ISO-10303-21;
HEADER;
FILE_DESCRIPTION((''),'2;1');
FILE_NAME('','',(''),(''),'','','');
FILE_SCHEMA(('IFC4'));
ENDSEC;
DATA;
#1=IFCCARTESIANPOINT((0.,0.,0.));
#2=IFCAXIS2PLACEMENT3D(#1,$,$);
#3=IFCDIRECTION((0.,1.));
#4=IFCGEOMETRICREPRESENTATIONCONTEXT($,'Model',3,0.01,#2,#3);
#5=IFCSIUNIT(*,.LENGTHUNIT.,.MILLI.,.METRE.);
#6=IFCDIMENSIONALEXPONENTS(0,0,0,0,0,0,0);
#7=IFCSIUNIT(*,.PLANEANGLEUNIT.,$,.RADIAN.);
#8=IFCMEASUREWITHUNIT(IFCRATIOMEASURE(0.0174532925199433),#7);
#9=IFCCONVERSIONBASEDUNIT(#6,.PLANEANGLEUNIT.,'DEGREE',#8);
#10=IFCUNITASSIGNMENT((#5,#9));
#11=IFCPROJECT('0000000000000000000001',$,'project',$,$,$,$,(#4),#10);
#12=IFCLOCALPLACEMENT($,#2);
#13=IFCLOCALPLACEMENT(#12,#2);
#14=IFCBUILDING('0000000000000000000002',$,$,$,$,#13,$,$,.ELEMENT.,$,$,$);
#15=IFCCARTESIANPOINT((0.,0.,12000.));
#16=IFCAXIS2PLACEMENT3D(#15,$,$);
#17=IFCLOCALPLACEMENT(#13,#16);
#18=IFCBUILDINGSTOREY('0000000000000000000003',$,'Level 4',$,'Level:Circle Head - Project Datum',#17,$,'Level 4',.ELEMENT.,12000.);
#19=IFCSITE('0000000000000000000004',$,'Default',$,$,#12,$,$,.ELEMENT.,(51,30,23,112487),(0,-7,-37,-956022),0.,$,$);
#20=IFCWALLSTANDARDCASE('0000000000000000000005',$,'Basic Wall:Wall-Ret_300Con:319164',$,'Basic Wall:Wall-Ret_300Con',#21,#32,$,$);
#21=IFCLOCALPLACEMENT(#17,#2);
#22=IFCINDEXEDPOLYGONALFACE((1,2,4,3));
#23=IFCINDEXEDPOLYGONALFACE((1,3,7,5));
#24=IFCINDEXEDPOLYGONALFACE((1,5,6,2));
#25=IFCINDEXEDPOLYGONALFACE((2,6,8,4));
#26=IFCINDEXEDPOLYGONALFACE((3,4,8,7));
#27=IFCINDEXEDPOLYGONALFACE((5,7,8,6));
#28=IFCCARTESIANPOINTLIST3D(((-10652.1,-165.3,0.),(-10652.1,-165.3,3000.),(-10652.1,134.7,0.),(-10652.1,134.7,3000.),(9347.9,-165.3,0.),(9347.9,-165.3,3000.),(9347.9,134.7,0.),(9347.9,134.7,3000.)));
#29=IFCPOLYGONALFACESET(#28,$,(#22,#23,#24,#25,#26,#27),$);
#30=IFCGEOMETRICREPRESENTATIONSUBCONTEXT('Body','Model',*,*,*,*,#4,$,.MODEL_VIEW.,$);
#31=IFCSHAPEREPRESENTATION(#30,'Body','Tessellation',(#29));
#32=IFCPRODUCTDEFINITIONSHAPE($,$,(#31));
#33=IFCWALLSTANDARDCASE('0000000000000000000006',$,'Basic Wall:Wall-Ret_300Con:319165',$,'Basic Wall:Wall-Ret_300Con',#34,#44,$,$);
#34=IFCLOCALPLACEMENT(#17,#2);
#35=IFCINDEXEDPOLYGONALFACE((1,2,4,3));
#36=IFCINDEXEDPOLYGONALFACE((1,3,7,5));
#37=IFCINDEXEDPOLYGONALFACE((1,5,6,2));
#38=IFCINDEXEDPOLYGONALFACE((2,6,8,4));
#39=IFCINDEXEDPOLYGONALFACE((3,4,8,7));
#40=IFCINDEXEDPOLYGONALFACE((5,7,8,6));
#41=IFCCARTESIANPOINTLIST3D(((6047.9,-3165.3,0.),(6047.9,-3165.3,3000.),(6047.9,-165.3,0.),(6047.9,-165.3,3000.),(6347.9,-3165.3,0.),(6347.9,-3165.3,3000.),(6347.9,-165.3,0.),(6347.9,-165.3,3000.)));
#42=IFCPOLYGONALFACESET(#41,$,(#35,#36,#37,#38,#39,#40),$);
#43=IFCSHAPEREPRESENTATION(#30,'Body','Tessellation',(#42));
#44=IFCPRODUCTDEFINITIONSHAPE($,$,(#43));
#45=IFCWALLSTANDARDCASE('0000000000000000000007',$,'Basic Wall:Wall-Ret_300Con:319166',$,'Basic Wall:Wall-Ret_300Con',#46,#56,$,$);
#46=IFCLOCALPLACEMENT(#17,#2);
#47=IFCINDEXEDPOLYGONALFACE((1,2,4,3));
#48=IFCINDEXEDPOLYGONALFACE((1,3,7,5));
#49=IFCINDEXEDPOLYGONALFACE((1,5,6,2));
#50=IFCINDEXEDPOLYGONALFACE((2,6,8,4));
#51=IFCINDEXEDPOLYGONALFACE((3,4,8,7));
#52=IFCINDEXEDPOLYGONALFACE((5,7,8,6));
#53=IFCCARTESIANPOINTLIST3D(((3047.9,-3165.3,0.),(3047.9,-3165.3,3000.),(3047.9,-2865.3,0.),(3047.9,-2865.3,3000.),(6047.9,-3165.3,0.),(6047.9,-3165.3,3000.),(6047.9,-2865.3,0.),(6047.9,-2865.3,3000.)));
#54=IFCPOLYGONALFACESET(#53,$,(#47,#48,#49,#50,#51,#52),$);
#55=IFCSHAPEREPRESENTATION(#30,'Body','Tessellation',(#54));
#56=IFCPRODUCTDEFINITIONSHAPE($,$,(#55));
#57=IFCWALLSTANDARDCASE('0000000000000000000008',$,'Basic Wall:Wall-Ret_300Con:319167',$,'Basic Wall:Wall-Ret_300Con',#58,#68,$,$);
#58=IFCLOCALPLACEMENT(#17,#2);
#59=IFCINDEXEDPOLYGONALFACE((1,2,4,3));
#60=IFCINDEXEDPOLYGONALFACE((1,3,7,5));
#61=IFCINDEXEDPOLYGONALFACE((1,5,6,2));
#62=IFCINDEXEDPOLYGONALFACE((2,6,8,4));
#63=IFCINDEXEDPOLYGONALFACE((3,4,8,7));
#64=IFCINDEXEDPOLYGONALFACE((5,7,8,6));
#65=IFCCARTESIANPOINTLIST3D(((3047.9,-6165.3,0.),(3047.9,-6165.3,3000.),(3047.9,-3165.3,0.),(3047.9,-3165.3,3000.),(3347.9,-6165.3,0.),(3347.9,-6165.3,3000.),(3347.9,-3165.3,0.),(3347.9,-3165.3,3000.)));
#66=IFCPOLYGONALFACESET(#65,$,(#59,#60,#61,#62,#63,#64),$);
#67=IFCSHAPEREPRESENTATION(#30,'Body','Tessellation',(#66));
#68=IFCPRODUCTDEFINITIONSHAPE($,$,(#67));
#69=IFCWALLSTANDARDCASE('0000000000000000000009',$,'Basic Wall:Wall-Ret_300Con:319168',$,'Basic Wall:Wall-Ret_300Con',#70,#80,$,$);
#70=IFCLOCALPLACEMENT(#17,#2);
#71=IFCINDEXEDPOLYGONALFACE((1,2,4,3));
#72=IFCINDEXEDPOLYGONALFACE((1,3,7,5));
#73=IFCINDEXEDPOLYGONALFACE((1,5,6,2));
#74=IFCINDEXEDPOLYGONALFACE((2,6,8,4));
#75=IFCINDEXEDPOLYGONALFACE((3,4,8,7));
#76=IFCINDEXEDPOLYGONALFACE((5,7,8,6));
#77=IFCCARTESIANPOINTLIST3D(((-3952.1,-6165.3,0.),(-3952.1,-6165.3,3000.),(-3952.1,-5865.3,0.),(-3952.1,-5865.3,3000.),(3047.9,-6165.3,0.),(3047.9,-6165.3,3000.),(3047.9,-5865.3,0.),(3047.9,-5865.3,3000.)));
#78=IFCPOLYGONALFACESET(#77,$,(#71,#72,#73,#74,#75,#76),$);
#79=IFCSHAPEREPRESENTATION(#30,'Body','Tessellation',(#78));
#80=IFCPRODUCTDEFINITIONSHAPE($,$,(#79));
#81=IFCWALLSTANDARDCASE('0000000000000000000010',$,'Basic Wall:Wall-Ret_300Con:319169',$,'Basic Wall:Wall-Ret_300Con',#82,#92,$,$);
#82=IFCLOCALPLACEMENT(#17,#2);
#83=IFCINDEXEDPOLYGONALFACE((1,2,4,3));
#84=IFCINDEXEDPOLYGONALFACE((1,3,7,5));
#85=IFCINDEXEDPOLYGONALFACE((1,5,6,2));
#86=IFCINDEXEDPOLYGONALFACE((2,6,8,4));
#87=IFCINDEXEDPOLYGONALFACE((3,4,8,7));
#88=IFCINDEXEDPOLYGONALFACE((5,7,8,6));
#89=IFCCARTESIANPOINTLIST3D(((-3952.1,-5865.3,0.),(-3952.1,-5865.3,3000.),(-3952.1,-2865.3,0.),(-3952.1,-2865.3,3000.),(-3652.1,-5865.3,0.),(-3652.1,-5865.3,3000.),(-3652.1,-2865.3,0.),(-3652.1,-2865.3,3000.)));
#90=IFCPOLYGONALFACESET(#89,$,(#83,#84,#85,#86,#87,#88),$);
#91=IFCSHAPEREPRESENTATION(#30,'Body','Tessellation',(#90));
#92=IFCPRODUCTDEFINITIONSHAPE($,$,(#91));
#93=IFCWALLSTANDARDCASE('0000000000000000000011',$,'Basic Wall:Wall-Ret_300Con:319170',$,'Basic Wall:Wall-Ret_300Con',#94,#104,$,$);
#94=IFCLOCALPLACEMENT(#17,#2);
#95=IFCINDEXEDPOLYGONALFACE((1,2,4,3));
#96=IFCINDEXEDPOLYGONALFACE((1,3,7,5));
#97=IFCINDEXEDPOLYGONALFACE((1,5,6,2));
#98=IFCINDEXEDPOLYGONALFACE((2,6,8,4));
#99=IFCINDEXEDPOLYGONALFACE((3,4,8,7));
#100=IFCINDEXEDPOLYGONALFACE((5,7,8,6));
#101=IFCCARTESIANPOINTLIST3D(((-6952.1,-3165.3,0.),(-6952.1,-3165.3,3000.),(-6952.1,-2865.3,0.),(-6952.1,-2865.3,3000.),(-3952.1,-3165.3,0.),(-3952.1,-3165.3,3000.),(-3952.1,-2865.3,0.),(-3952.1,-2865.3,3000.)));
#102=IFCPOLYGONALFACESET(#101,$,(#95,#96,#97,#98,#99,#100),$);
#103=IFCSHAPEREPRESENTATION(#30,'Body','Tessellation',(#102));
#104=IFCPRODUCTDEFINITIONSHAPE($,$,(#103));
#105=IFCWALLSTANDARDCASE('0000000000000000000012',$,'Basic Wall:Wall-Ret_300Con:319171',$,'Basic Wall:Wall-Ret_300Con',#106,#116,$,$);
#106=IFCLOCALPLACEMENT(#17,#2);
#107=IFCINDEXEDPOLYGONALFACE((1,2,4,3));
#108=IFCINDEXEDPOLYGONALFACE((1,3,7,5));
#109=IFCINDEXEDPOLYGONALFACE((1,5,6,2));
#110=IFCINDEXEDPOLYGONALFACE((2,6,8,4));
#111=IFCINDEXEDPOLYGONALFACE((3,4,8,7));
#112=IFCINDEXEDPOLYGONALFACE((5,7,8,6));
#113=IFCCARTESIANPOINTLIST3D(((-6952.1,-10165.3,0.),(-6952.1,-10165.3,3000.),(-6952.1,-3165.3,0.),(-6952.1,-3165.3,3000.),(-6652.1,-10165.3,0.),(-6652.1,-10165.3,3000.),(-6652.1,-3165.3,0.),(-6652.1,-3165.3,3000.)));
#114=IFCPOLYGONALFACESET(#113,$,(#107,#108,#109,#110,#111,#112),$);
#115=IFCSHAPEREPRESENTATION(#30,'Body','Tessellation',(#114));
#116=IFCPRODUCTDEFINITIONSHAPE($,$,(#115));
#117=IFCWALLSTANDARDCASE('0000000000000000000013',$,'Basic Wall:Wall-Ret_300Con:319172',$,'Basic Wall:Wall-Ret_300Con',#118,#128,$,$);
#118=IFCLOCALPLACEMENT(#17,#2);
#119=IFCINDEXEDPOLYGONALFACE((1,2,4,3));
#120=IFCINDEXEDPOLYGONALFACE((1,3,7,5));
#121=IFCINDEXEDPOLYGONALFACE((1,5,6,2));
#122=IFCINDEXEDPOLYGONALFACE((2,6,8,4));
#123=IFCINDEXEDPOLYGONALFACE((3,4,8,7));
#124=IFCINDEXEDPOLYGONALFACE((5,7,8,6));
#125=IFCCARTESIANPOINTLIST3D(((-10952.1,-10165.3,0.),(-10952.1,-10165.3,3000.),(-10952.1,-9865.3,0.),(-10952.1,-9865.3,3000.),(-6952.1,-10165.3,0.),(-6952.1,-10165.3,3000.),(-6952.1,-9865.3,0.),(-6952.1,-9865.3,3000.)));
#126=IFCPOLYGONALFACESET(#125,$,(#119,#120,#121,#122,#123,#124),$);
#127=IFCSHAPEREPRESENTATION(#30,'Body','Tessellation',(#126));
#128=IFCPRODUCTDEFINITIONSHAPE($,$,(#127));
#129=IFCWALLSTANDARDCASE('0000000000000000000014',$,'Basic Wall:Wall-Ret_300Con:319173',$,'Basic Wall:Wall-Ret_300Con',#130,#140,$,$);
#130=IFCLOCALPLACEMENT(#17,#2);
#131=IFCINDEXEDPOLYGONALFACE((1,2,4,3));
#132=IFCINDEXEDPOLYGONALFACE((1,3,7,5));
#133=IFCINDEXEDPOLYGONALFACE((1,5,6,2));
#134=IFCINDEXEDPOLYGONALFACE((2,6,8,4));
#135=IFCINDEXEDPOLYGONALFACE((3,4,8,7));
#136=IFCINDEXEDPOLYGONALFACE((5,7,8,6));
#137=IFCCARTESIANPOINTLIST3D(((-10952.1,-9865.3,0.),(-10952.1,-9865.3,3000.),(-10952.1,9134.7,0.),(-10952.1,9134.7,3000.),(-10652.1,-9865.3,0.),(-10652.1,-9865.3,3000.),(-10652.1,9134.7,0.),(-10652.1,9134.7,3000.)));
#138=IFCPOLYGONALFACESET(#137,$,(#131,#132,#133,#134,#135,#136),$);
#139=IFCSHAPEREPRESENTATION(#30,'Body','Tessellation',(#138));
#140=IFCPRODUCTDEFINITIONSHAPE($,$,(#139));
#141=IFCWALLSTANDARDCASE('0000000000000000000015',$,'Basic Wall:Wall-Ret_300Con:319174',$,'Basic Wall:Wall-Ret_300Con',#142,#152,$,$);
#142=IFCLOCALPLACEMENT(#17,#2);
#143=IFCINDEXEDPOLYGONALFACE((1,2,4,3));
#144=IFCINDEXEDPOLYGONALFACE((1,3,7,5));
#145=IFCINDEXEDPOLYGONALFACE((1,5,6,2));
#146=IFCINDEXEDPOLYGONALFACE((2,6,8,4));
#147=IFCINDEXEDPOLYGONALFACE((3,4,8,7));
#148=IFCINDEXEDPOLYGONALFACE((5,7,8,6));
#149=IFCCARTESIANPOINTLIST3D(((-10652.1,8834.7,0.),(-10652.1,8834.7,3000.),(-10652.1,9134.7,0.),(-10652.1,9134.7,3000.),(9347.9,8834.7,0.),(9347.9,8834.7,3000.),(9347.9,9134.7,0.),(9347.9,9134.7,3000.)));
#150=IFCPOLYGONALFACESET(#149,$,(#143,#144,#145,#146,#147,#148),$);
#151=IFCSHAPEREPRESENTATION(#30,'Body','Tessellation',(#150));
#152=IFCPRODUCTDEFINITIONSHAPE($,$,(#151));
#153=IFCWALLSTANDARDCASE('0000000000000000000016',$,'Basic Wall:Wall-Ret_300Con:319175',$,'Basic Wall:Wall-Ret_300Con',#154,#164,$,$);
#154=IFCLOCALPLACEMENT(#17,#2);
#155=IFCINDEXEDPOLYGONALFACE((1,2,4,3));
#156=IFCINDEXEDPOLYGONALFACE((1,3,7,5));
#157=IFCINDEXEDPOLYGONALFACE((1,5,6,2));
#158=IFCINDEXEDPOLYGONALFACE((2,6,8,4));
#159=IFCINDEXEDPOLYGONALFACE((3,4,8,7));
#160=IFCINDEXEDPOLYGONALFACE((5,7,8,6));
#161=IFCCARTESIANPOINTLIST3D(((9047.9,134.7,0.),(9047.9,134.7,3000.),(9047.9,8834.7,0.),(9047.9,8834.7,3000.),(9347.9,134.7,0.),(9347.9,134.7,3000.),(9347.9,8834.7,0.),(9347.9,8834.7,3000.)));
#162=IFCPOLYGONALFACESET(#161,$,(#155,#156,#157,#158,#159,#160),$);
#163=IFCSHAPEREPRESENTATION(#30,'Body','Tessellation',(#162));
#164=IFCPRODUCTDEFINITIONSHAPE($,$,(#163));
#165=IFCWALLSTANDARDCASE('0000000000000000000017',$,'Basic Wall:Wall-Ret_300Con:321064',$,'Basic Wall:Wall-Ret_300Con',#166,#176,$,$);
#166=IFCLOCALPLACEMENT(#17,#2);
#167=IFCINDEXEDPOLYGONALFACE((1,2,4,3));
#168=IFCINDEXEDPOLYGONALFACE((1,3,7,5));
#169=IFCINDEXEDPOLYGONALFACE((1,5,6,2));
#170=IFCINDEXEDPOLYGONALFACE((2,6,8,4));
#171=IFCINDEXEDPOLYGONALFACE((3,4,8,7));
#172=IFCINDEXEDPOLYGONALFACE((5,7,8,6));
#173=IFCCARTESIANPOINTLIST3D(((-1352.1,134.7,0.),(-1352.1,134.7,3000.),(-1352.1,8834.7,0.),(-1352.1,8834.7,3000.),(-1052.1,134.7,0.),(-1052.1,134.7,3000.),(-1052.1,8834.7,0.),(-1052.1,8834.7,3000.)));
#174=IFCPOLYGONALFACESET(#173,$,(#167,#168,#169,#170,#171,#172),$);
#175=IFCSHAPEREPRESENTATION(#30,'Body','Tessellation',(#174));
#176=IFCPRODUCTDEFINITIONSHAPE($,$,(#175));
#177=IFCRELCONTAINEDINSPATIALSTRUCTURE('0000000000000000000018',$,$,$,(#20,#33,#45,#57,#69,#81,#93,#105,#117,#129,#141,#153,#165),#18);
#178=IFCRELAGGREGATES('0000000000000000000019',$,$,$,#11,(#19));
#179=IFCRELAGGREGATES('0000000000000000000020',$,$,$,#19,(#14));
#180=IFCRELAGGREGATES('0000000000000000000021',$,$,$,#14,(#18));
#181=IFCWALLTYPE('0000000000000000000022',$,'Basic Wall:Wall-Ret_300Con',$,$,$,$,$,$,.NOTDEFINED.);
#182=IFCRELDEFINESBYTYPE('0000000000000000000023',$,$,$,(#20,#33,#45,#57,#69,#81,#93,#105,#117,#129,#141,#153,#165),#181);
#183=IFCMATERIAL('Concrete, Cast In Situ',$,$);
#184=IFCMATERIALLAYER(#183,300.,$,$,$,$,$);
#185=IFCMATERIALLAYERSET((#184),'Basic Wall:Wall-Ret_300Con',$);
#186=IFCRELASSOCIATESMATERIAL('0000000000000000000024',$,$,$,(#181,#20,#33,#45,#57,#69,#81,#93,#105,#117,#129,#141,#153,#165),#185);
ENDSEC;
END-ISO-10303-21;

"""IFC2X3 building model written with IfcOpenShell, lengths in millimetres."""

from ifc_helpers import new_model, entity, si_unit, converted_unit, direction, frame, frame_2d, origin, place, context, subcontext, project, spatial, rectangle, extrude, material, layer, layer_set, layer_usage, type_object, element, save


model = new_model("IFC2X3")

# Units and contexts
model_context = context("Model", 3, precision=0.01, world=origin(), true_north=direction((0.0, 1.0)))
body_context = subcontext(model_context, "Body", "Model", "MODEL_VIEW")
ifc_project = project(units=[si_unit("LENGTHUNIT", "METRE", prefix="MILLI"), converted_unit("PLANEANGLEUNIT", "DEGREE", entity("IfcRatioMeasure", 0.0174532925199433), si_unit("PLANEANGLEUNIT", "RADIAN"), dimensions=[0, 0, 0, 0, 0, 0, 0])], contexts=[model_context])

# Site, building, storey
site_placement = place(None, origin())
site = spatial("IfcSite", under=ifc_project, at=site_placement, Name="Default", CompositionType="ELEMENT", RefLatitude=(51, 30, 23, 112487), RefLongitude=(0, -7, -37, -956022), RefElevation=0.0)
building_placement = place(site_placement, origin())
building = spatial("IfcBuilding", under=site, at=building_placement, CompositionType="ELEMENT")
storey_placement = place(building_placement, frame((0.0, 0.0, 12000.0)))
storey = spatial("IfcBuildingStorey", under=building, at=storey_placement, Name="Level 4", ObjectType="Level:Circle Head - Project Datum", LongName="Level 4", CompositionType="ELEMENT", Elevation=12000.0)

# Walls
ifc_material_1 = material(Name="Concrete, Cast In Situ")
ifc_layer_1 = layer(ifc_material_1, 300.0)
ifc_layer_set_1 = layer_set([ifc_layer_1], Name="Basic Wall:Wall-Ret_300Con")
ifc_layer_usage_1 = layer_usage(ifc_layer_set_1, "AXIS2", "NEGATIVE", 150.0)
wall_type = type_object("IfcWallType", Name="Basic Wall:Wall-Ret_300Con", PredefinedType="NOTDEFINED", material=ifc_layer_set_1)
wall_1_placement = place(storey_placement, frame((9347.9, -15.3, 0.0), z_axis=(0.0, 0.0, 1.0), x_axis=(-1.0, 0.0, 0.0)))
element("IfcWallStandardCase", 1, at=wall_1_placement, inside=storey, type_object=wall_type, material=ifc_layer_usage_1, Name="Basic Wall:Wall-Ret_300Con:319164", ObjectType="Basic Wall:Wall-Ret_300Con", context=body_context, shape_type="SweptSolid", body=[
    extrude(rectangle(XDim=20000.0, YDim=300.0, at=frame_2d((10000.0, 0.0), x_axis=(-1.0, 0.0))), origin(), (0.0, 0.0, 1.0), 3000.0),
])
ifc_layer_usage_2 = layer_usage(ifc_layer_set_1, "AXIS2", "NEGATIVE", 150.0)
wall_2_placement = place(storey_placement, frame((6197.9, -165.3, 0.0), z_axis=(0.0, 0.0, 1.0), x_axis=(0.0, -1.0, 0.0)))
element("IfcWallStandardCase", 2, at=wall_2_placement, inside=storey, type_object=wall_type, material=ifc_layer_usage_2, Name="Basic Wall:Wall-Ret_300Con:319165", ObjectType="Basic Wall:Wall-Ret_300Con", context=body_context, shape_type="SweptSolid", body=[
    extrude(rectangle(XDim=3000.0, YDim=300.0, at=frame_2d((1500.0, 0.0), x_axis=(-1.0, 0.0))), origin(), (0.0, 0.0, 1.0), 3000.0),
])
ifc_layer_usage_3 = layer_usage(ifc_layer_set_1, "AXIS2", "NEGATIVE", 150.0)
wall_3_placement = place(storey_placement, frame((6047.9, -3015.3, 0.0), z_axis=(0.0, 0.0, 1.0), x_axis=(-1.0, 0.0, 0.0)))
element("IfcWallStandardCase", 3, at=wall_3_placement, inside=storey, type_object=wall_type, material=ifc_layer_usage_3, Name="Basic Wall:Wall-Ret_300Con:319166", ObjectType="Basic Wall:Wall-Ret_300Con", context=body_context, shape_type="SweptSolid", body=[
    extrude(rectangle(XDim=3000.0, YDim=300.0, at=frame_2d((1500.0, 0.0), x_axis=(-1.0, 0.0))), origin(), (0.0, 0.0, 1.0), 3000.0),
])
ifc_layer_usage_4 = layer_usage(ifc_layer_set_1, "AXIS2", "NEGATIVE", 150.0)
wall_4_placement = place(storey_placement, frame((3197.9, -3165.3, 0.0), z_axis=(0.0, 0.0, 1.0), x_axis=(0.0, -1.0, 0.0)))
element("IfcWallStandardCase", 4, at=wall_4_placement, inside=storey, type_object=wall_type, material=ifc_layer_usage_4, Name="Basic Wall:Wall-Ret_300Con:319167", ObjectType="Basic Wall:Wall-Ret_300Con", context=body_context, shape_type="SweptSolid", body=[
    extrude(rectangle(XDim=3000.0, YDim=300.0, at=frame_2d((1500.0, 0.0), x_axis=(-1.0, 0.0))), origin(), (0.0, 0.0, 1.0), 3000.0),
])
ifc_layer_usage_5 = layer_usage(ifc_layer_set_1, "AXIS2", "NEGATIVE", 150.0)
wall_5_placement = place(storey_placement, frame((3047.9, -6015.3, 0.0), z_axis=(0.0, 0.0, 1.0), x_axis=(-1.0, 0.0, 0.0)))
element("IfcWallStandardCase", 5, at=wall_5_placement, inside=storey, type_object=wall_type, material=ifc_layer_usage_5, Name="Basic Wall:Wall-Ret_300Con:319168", ObjectType="Basic Wall:Wall-Ret_300Con", context=body_context, shape_type="SweptSolid", body=[
    extrude(rectangle(XDim=7000.0, YDim=300.0, at=frame_2d((3500.0, 0.0), x_axis=(-1.0, 0.0))), origin(), (0.0, 0.0, 1.0), 3000.0),
])
ifc_layer_usage_6 = layer_usage(ifc_layer_set_1, "AXIS2", "NEGATIVE", 150.0)
wall_6_placement = place(storey_placement, frame((-3802.1, -5865.3, 0.0), z_axis=(0.0, 0.0, 1.0), x_axis=(0.0, 1.0, 0.0)))
element("IfcWallStandardCase", 6, at=wall_6_placement, inside=storey, type_object=wall_type, material=ifc_layer_usage_6, Name="Basic Wall:Wall-Ret_300Con:319169", ObjectType="Basic Wall:Wall-Ret_300Con", context=body_context, shape_type="SweptSolid", body=[
    extrude(rectangle(XDim=3000.0, YDim=300.0, at=frame_2d((1500.0, 0.0), x_axis=(-1.0, 0.0))), origin(), (0.0, 0.0, 1.0), 3000.0),
])
ifc_layer_usage_7 = layer_usage(ifc_layer_set_1, "AXIS2", "NEGATIVE", 150.0)
wall_7_placement = place(storey_placement, frame((-3952.1, -3015.3, 0.0), z_axis=(0.0, 0.0, 1.0), x_axis=(-1.0, 0.0, 0.0)))
element("IfcWallStandardCase", 7, at=wall_7_placement, inside=storey, type_object=wall_type, material=ifc_layer_usage_7, Name="Basic Wall:Wall-Ret_300Con:319170", ObjectType="Basic Wall:Wall-Ret_300Con", context=body_context, shape_type="SweptSolid", body=[
    extrude(rectangle(XDim=3000.0, YDim=300.0, at=frame_2d((1500.0, 0.0), x_axis=(-1.0, 0.0))), origin(), (0.0, 0.0, 1.0), 3000.0),
])
ifc_layer_usage_8 = layer_usage(ifc_layer_set_1, "AXIS2", "NEGATIVE", 150.0)
wall_8_placement = place(storey_placement, frame((-6802.1, -3165.3, 0.0), z_axis=(0.0, 0.0, 1.0), x_axis=(0.0, -1.0, 0.0)))
element("IfcWallStandardCase", 8, at=wall_8_placement, inside=storey, type_object=wall_type, material=ifc_layer_usage_8, Name="Basic Wall:Wall-Ret_300Con:319171", ObjectType="Basic Wall:Wall-Ret_300Con", context=body_context, shape_type="SweptSolid", body=[
    extrude(rectangle(XDim=7000.0, YDim=300.0, at=frame_2d((3500.0, 0.0), x_axis=(-1.0, 0.0))), origin(), (0.0, 0.0, 1.0), 3000.0),
])
ifc_layer_usage_9 = layer_usage(ifc_layer_set_1, "AXIS2", "NEGATIVE", 150.0)
wall_9_placement = place(storey_placement, frame((-6952.1, -10015.3, 0.0), z_axis=(0.0, 0.0, 1.0), x_axis=(-1.0, 0.0, 0.0)))
element("IfcWallStandardCase", 9, at=wall_9_placement, inside=storey, type_object=wall_type, material=ifc_layer_usage_9, Name="Basic Wall:Wall-Ret_300Con:319172", ObjectType="Basic Wall:Wall-Ret_300Con", context=body_context, shape_type="SweptSolid", body=[
    extrude(rectangle(XDim=4000.0, YDim=300.0, at=frame_2d((2000.0, 0.0), x_axis=(-1.0, 0.0))), origin(), (0.0, 0.0, 1.0), 3000.0),
])
ifc_layer_usage_10 = layer_usage(ifc_layer_set_1, "AXIS2", "NEGATIVE", 150.0)
wall_10_placement = place(storey_placement, frame((-10802.1, -9865.3, 0.0), z_axis=(0.0, 0.0, 1.0), x_axis=(0.0, 1.0, 0.0)))
element("IfcWallStandardCase", 10, at=wall_10_placement, inside=storey, type_object=wall_type, material=ifc_layer_usage_10, Name="Basic Wall:Wall-Ret_300Con:319173", ObjectType="Basic Wall:Wall-Ret_300Con", context=body_context, shape_type="SweptSolid", body=[
    extrude(rectangle(XDim=19000.0, YDim=300.0, at=frame_2d((9500.0, 0.0), x_axis=(-1.0, 0.0))), origin(), (0.0, 0.0, 1.0), 3000.0),
])
ifc_layer_usage_11 = layer_usage(ifc_layer_set_1, "AXIS2", "NEGATIVE", 150.0)
wall_11_placement = place(storey_placement, frame((-10652.1, 8984.7, 0.0)))
element("IfcWallStandardCase", 11, at=wall_11_placement, inside=storey, type_object=wall_type, material=ifc_layer_usage_11, Name="Basic Wall:Wall-Ret_300Con:319174", ObjectType="Basic Wall:Wall-Ret_300Con", context=body_context, shape_type="SweptSolid", body=[
    extrude(rectangle(XDim=20000.0, YDim=300.0, at=frame_2d((10000.0, 0.0), x_axis=(-1.0, 0.0))), origin(), (0.0, 0.0, 1.0), 3000.0),
])
ifc_layer_usage_12 = layer_usage(ifc_layer_set_1, "AXIS2", "NEGATIVE", 150.0)
wall_12_placement = place(storey_placement, frame((9197.9, 8834.7, 0.0), z_axis=(0.0, 0.0, 1.0), x_axis=(0.0, -1.0, 0.0)))
element("IfcWallStandardCase", 12, at=wall_12_placement, inside=storey, type_object=wall_type, material=ifc_layer_usage_12, Name="Basic Wall:Wall-Ret_300Con:319175", ObjectType="Basic Wall:Wall-Ret_300Con", context=body_context, shape_type="SweptSolid", body=[
    extrude(rectangle(XDim=8700.0, YDim=300.0, at=frame_2d((4350.0, 0.0), x_axis=(-1.0, 0.0))), origin(), (0.0, 0.0, 1.0), 3000.0),
])
ifc_layer_usage_13 = layer_usage(ifc_layer_set_1, "AXIS2", "NEGATIVE", 150.0)
wall_13_placement = place(storey_placement, frame((-1202.1, 134.7, 0.0), z_axis=(0.0, 0.0, 1.0), x_axis=(0.0, 1.0, 0.0)))
element("IfcWallStandardCase", 13, at=wall_13_placement, inside=storey, type_object=wall_type, material=ifc_layer_usage_13, Name="Basic Wall:Wall-Ret_300Con:321064", ObjectType="Basic Wall:Wall-Ret_300Con", context=body_context, shape_type="SweptSolid", body=[
    extrude(rectangle(XDim=8700.0, YDim=300.0, at=frame_2d((4350.0, 0.0), x_axis=(-1.0, 0.0))), origin(), (0.0, 0.0, 1.0), 3000.0),
])

save(model, "model.ifc")
